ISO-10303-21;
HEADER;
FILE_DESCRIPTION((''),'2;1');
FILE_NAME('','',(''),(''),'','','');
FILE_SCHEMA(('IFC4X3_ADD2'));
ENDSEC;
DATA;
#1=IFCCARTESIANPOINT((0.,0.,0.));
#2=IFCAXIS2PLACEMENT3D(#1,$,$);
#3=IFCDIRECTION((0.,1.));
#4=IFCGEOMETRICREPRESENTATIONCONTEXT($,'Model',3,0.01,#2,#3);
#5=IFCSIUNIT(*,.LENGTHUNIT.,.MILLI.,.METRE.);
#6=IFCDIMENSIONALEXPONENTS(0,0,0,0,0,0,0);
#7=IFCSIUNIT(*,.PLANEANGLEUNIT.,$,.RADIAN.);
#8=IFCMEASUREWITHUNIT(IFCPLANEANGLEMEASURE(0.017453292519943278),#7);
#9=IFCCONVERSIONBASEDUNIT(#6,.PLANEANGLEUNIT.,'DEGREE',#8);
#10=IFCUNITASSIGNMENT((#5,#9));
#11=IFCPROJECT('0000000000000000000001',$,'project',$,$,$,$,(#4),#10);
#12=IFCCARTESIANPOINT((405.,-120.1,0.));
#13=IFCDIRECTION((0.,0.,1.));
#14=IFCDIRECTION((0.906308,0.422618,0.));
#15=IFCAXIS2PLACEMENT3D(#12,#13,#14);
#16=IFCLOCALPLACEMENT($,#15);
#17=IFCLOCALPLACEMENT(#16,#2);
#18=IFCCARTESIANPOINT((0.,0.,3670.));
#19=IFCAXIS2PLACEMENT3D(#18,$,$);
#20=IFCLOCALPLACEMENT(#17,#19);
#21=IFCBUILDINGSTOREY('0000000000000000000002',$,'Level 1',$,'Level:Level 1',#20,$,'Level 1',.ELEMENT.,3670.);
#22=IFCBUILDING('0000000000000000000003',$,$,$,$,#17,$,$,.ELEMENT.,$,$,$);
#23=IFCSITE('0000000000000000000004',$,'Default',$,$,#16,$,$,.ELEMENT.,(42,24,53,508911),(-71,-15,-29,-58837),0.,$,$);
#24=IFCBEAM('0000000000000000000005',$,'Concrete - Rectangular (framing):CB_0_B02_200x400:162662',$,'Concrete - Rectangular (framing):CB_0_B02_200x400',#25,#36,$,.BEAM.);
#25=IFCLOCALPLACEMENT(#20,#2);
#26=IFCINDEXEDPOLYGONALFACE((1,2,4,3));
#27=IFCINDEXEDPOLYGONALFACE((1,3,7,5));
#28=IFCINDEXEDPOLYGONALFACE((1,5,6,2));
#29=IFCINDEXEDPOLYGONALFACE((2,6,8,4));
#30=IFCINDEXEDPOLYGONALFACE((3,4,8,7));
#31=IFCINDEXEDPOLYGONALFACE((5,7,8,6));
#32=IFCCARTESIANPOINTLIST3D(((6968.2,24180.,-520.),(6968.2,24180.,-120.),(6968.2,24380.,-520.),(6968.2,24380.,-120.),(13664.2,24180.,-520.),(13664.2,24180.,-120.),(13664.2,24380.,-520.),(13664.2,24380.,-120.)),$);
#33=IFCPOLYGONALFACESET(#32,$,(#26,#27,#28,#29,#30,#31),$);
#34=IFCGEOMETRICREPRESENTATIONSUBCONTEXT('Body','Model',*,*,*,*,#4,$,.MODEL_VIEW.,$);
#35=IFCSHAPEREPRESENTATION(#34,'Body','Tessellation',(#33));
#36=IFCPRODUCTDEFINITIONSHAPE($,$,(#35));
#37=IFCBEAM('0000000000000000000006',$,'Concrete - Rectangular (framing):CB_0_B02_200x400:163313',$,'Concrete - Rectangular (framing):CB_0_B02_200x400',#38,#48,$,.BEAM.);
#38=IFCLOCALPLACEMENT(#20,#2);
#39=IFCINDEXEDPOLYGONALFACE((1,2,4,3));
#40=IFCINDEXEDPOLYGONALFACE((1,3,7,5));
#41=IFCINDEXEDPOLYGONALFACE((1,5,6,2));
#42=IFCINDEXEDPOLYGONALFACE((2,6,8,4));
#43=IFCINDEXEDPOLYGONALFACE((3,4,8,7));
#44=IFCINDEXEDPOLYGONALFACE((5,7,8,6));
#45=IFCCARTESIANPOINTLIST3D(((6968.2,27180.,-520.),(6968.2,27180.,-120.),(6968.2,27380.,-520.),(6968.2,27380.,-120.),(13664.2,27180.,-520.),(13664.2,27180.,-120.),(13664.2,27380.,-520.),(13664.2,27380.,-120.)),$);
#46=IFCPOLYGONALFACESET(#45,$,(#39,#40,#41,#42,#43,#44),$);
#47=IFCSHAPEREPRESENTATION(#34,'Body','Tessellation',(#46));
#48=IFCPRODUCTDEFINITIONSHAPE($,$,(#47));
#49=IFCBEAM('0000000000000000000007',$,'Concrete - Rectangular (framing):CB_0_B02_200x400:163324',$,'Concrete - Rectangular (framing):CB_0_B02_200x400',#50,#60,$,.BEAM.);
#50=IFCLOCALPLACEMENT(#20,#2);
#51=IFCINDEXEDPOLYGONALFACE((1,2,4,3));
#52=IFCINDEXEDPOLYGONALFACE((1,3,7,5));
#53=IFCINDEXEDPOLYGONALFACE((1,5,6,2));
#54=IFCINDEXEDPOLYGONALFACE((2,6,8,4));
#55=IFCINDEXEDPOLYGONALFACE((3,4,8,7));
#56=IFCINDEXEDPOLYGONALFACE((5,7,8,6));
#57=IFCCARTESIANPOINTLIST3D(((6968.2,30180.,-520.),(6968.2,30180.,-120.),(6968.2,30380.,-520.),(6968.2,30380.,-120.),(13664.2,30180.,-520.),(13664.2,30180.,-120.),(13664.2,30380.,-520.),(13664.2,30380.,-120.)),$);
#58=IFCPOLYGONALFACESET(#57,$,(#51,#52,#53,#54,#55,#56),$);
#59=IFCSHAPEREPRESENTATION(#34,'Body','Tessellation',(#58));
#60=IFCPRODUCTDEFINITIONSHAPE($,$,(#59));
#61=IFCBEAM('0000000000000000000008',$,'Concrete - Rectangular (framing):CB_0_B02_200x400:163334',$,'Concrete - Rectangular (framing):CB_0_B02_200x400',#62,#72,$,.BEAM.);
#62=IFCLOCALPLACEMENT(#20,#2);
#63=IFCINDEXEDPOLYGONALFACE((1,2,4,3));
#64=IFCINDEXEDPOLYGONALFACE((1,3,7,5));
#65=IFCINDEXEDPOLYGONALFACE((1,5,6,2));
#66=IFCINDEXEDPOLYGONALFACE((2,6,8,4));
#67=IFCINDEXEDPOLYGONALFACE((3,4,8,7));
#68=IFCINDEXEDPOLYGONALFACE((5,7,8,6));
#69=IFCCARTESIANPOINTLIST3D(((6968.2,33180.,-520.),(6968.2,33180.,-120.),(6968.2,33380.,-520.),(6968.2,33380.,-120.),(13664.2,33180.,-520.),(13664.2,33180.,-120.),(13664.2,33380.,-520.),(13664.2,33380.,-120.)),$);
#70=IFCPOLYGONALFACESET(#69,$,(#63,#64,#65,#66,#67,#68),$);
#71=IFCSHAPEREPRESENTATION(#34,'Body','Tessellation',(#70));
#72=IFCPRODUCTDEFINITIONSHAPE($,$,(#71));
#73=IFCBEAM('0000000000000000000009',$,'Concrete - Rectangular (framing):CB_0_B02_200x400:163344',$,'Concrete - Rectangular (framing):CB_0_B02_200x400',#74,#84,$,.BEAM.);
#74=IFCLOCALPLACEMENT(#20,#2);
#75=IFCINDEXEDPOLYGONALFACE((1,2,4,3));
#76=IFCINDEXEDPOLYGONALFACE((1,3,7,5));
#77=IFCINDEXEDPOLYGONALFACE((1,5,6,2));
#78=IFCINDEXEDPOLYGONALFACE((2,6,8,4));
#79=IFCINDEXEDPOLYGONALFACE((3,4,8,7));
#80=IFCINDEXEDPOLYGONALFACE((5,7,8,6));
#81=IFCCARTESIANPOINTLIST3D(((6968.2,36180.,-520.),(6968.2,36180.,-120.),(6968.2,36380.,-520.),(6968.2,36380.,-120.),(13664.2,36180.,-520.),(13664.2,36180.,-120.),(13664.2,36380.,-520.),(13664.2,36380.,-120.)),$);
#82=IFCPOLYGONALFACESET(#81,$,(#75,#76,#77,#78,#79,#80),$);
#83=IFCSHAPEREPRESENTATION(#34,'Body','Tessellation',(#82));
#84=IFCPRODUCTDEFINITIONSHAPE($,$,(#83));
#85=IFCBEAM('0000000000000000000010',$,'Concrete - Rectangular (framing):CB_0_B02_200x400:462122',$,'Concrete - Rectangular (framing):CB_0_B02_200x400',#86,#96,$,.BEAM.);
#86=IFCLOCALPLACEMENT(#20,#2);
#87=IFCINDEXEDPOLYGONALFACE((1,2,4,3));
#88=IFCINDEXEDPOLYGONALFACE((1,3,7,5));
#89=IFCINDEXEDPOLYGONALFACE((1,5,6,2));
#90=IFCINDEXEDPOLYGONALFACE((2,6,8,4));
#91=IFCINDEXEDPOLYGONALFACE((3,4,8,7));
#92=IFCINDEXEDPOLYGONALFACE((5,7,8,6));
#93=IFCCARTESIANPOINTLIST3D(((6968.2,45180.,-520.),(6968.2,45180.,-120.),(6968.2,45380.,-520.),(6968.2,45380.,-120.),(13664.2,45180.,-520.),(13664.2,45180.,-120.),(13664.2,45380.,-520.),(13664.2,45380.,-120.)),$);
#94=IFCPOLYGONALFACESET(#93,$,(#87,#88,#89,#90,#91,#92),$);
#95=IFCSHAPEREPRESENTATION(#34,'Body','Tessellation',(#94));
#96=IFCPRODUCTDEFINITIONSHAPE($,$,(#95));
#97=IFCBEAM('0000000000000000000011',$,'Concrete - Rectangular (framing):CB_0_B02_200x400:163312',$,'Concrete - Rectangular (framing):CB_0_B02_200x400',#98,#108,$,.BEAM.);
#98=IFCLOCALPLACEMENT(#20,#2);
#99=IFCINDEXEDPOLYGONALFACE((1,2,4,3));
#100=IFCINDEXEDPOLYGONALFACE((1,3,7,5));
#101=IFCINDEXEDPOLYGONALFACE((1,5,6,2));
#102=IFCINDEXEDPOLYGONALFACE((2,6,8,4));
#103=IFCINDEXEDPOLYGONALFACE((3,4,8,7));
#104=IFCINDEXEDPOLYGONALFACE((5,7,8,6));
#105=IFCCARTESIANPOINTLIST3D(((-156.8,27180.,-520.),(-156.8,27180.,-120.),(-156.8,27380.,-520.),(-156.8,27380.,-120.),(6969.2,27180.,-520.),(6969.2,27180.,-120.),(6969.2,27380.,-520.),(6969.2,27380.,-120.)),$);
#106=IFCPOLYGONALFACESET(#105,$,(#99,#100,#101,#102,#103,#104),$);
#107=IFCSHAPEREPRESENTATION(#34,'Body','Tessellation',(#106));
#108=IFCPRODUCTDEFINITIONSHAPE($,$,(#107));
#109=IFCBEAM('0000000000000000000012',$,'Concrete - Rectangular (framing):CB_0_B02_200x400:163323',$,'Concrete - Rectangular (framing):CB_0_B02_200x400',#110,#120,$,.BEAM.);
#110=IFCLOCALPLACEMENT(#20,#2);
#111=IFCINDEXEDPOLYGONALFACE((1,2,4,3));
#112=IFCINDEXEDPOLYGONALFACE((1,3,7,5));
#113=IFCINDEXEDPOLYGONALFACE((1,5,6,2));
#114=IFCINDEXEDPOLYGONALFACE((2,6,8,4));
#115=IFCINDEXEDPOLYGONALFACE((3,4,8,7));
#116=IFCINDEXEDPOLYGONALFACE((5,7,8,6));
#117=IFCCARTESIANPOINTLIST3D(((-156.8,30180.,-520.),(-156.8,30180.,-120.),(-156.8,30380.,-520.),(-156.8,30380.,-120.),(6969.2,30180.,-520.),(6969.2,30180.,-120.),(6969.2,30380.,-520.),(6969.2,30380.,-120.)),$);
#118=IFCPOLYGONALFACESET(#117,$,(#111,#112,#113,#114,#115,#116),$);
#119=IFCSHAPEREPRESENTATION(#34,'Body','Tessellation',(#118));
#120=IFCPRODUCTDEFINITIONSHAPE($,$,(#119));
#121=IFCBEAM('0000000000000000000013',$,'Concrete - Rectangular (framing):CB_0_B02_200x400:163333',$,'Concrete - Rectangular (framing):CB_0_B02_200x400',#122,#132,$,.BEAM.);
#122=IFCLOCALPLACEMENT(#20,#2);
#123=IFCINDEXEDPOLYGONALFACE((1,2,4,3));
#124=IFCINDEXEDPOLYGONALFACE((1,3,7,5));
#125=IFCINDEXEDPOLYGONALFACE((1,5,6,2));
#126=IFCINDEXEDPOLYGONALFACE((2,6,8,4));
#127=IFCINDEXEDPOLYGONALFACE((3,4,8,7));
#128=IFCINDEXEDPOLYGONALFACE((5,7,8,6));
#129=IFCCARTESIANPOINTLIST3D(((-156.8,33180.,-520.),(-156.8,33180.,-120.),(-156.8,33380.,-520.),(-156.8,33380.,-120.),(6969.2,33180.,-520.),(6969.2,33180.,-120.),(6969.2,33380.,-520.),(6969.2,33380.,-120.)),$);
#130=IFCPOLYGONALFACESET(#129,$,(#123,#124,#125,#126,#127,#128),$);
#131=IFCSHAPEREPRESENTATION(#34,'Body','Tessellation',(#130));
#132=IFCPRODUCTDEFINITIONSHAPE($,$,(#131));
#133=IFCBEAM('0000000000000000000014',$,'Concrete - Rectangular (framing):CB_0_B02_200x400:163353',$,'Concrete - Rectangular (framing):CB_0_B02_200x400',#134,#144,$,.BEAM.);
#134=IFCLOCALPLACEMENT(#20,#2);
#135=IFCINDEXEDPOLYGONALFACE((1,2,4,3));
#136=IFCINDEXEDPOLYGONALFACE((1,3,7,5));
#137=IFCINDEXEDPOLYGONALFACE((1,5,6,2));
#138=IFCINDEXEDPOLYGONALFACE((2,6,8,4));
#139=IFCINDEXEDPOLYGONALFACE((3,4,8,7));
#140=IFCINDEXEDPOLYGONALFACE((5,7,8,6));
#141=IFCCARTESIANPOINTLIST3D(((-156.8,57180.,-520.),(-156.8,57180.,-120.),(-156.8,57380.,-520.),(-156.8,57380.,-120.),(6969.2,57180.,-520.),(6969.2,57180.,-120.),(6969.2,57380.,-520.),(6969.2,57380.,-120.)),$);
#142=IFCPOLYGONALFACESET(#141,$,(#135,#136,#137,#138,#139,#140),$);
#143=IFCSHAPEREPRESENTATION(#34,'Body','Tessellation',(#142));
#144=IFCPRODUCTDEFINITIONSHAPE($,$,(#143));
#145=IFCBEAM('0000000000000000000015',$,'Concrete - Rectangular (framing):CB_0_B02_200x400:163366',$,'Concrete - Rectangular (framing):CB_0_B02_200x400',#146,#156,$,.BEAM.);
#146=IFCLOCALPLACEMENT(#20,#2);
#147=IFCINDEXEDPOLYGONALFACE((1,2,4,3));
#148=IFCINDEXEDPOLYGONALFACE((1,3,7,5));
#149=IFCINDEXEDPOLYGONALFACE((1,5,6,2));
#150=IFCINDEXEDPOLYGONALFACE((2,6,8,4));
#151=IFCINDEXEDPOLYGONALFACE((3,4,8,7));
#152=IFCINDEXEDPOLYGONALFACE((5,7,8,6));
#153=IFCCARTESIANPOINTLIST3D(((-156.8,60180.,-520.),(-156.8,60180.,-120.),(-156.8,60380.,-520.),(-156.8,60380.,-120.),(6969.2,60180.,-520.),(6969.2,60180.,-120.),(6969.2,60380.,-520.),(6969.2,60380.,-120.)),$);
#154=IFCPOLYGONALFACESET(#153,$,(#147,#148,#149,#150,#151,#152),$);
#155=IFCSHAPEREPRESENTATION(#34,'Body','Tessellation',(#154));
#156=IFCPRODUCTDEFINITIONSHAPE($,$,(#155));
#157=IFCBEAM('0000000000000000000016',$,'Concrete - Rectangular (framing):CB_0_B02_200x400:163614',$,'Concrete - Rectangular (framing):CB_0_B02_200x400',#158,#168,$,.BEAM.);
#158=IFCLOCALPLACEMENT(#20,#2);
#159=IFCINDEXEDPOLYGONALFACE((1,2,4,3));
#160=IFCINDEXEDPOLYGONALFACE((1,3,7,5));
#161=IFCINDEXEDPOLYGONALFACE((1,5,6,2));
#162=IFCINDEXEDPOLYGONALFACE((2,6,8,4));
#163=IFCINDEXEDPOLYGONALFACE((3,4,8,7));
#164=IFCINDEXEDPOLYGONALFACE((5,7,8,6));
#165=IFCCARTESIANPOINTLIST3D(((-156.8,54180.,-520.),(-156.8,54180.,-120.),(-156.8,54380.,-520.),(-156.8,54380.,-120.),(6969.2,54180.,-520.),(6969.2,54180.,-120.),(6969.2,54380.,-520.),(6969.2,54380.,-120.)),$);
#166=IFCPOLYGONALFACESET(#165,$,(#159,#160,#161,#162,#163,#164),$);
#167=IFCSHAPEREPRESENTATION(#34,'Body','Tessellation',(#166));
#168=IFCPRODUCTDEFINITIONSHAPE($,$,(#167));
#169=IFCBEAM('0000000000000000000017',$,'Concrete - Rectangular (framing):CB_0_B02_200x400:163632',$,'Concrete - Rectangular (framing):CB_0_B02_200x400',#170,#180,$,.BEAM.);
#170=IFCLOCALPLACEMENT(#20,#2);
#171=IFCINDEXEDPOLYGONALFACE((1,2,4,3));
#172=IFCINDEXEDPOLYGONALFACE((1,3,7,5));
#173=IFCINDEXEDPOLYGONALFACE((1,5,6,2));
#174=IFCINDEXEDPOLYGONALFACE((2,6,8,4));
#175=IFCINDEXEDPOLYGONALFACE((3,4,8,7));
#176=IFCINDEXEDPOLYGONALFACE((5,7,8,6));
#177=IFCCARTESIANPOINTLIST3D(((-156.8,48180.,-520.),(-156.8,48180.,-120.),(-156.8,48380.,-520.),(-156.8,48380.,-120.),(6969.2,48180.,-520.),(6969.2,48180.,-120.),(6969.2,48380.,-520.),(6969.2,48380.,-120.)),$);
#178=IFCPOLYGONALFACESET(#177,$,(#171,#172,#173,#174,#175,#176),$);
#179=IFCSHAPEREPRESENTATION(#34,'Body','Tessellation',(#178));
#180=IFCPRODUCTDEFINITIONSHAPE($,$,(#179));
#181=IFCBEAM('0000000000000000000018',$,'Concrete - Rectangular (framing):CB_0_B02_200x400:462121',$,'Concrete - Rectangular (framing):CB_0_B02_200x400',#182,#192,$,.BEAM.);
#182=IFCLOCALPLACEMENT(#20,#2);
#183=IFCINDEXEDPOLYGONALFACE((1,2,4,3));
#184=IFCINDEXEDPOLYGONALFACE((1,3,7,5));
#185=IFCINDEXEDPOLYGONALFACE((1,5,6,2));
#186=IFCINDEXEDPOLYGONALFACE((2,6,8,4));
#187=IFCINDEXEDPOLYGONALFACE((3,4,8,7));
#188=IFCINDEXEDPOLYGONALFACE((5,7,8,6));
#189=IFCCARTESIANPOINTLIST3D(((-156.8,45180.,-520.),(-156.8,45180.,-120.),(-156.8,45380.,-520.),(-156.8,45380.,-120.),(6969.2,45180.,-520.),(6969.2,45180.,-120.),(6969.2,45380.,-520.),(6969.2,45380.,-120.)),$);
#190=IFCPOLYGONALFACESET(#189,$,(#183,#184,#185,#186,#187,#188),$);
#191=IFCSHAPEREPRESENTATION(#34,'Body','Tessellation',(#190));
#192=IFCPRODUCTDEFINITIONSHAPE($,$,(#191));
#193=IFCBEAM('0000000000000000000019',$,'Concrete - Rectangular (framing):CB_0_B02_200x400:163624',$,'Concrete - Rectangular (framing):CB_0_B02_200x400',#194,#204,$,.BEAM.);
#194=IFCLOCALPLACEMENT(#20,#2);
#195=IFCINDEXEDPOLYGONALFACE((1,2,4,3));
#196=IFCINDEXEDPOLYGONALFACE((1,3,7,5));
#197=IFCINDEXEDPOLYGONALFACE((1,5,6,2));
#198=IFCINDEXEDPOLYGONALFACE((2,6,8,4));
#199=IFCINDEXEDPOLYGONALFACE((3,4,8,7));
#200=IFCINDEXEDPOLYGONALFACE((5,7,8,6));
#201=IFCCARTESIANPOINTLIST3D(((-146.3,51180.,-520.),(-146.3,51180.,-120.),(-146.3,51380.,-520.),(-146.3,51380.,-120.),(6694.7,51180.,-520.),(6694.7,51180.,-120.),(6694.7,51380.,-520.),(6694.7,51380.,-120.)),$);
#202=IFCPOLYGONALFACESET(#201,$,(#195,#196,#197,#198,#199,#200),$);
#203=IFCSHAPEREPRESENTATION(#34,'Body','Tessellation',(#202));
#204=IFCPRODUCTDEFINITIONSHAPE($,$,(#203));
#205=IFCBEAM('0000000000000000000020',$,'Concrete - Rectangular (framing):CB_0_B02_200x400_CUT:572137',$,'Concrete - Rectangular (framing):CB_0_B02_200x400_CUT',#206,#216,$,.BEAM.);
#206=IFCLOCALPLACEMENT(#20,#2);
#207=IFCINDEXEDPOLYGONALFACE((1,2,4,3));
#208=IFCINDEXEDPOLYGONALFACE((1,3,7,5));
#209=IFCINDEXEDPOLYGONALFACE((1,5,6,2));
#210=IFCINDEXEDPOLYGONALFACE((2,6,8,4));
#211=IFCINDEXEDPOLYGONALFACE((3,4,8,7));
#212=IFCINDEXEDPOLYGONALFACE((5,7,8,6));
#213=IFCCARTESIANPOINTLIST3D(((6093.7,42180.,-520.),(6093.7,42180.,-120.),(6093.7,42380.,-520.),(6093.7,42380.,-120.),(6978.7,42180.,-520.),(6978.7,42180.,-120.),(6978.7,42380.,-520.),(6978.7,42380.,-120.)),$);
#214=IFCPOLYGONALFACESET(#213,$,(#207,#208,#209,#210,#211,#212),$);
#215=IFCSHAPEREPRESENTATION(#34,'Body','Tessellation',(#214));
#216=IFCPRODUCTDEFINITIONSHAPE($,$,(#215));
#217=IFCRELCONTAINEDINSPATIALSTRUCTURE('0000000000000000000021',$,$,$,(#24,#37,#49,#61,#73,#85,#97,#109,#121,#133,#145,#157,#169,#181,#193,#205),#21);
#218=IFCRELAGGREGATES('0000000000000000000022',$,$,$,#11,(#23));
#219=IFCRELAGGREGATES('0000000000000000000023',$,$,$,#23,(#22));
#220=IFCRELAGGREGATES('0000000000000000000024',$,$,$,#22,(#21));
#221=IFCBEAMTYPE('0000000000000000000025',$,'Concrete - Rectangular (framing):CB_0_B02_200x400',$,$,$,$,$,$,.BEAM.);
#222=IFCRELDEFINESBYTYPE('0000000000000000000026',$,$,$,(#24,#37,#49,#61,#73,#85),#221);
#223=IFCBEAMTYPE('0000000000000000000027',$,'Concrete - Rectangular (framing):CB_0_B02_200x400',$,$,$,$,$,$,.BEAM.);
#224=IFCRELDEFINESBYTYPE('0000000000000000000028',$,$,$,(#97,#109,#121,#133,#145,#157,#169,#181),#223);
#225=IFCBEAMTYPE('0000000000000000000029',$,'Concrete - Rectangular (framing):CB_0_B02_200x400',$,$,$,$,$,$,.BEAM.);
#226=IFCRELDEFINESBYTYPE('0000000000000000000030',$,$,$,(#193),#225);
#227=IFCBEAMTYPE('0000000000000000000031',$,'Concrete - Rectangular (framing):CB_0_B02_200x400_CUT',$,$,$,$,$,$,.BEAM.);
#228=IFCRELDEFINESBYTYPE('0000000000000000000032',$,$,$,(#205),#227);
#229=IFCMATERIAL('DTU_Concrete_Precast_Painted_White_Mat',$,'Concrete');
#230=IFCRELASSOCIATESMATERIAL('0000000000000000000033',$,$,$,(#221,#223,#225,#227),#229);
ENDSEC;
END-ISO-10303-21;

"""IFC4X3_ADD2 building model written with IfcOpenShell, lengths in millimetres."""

from ifc_helpers import new_model, entity, si_unit, converted_unit, direction, frame, frame_2d, origin, origin_2d_with_axis, place, context, subcontext, project, spatial, rectangle, extrude, source, transform, mapped, material, material_profile, profile_set, type_object, type_shapes, element, save


model = new_model("IFC4X3_ADD2")

# Units and contexts
model_context = context("Model", 3, precision=0.01, world=origin(), true_north=direction((0.0, 1.0)))
body_context = subcontext(model_context, "Body", "Model", "MODEL_VIEW")
ifc_project = project(units=[si_unit("LENGTHUNIT", "METRE", prefix="MILLI"), converted_unit("PLANEANGLEUNIT", "DEGREE", entity("IfcPlaneAngleMeasure", 0.017453292519943278), si_unit("PLANEANGLEUNIT", "RADIAN"), dimensions=[0, 0, 0, 0, 0, 0, 0])], contexts=[model_context])

# Site, building, storey
site_placement = place(None, frame((405.0, -120.1, 0.0), z_axis=(0.0, 0.0, 1.0), x_axis=(0.906308, 0.422618, 0.0)))
site = spatial("IfcSite", under=ifc_project, at=site_placement, Name="Default", CompositionType="ELEMENT", RefLatitude=(42, 24, 53, 508911), RefLongitude=(-71, -15, -29, -58837), RefElevation=0.0)
building_placement = place(site_placement, origin())
building = spatial("IfcBuilding", under=site, at=building_placement, CompositionType="ELEMENT")
storey_placement = place(building_placement, frame((0.0, 0.0, 3670.0)))
storey = spatial("IfcBuildingStorey", under=building, at=storey_placement, Name="Level 1", ObjectType="Level:Level 1", LongName="Level 1", CompositionType="ELEMENT", Elevation=3670.0)

# Beams
ifc_material_1 = material(Name="DTU_Concrete_Precast_Painted_White_Mat", Category="Concrete")
ifc_material_profile_1 = material_profile(ifc_material_1, rectangle(XDim=7035.5, YDim=200.0, at=frame_2d((0.0, 0.0), x_axis=(1.0, 0.0))), Name="CB_0_B02_200x400")
ifc_profile_set_1 = profile_set([ifc_material_profile_1], Name="CB_0_B02_200x400")
beam_type_1 = type_object("IfcBeamType", Name="Concrete - Rectangular (framing):CB_0_B02_200x400", PredefinedType="BEAM", material=ifc_profile_set_1)
shared_shape_1 = source(origin(), body_context, "Body", "SweptSolid", [
    extrude(rectangle(XDim=6696.0, YDim=200.0, at=origin_2d_with_axis()), frame((0.0, 0.0, -200.0), z_axis=(0.0, 0.0, 1.0), x_axis=(-1.0, 0.0, 0.0)), (0.0, 0.0, 1.0), 400.0),
])
type_shapes(beam_type_1, [shared_shape_1])
for number, where, name in (
    (1, (10316.2, 24280.0, -320.0), "Concrete - Rectangular (framing):CB_0_B02_200x400:162662"),
    (2, (10316.2, 27280.0, -320.0), "Concrete - Rectangular (framing):CB_0_B02_200x400:163313"),
    (3, (10316.2, 30280.0, -320.0), "Concrete - Rectangular (framing):CB_0_B02_200x400:163324"),
    (4, (10316.2, 33280.0, -320.0), "Concrete - Rectangular (framing):CB_0_B02_200x400:163334"),
    (5, (10316.2, 36280.0, -320.0), "Concrete - Rectangular (framing):CB_0_B02_200x400:163344"),
    (6, (10316.2, 45280.0, -320.0), "Concrete - Rectangular (framing):CB_0_B02_200x400:462122"),
):
    element("IfcBeam", number, at=place(storey_placement, frame(where)), inside=storey, type_object=beam_type_1, Name=name, ObjectType="Concrete - Rectangular (framing):CB_0_B02_200x400", PredefinedType="BEAM", context=body_context, shape_type="MappedRepresentation", body=[
        mapped(shared_shape_1, transform((0.0, 0.0, 0.0), scale=1.0)),
    ])
beam_type_2 = type_object("IfcBeamType", Name="Concrete - Rectangular (framing):CB_0_B02_200x400", PredefinedType="BEAM", material=ifc_profile_set_1)
shared_shape_2 = source(origin(), body_context, "Body", "SweptSolid", [
    extrude(rectangle(XDim=7126.0, YDim=200.0, at=origin_2d_with_axis()), frame((0.0, 0.0, -200.0), z_axis=(0.0, 0.0, 1.0), x_axis=(-1.0, 0.0, 0.0)), (0.0, 0.0, 1.0), 400.0),
])
type_shapes(beam_type_2, [shared_shape_2])
for number, where, z_axis, x_axis, name in (
    (7, (3406.2, 27280.0, -320.0), (0.0, 0.0, 1.0), (-1.0, 0.0, 0.0), "Concrete - Rectangular (framing):CB_0_B02_200x400:163312"),
    (8, (3406.2, 30280.0, -320.0), (0.0, 0.0, 1.0), (-1.0, 0.0, 0.0), "Concrete - Rectangular (framing):CB_0_B02_200x400:163323"),
    (9, (3406.2, 33280.0, -320.0), (0.0, 0.0, 1.0), (-1.0, 0.0, 0.0), "Concrete - Rectangular (framing):CB_0_B02_200x400:163333"),
    (10, (3406.2, 57280.0, -320.0), (0.0, 0.0, 1.0), (-1.0, 0.0, 0.0), "Concrete - Rectangular (framing):CB_0_B02_200x400:163353"),
    (11, (3406.2, 60280.0, -320.0), (0.0, 0.0, 1.0), (-1.0, 0.0, 0.0), "Concrete - Rectangular (framing):CB_0_B02_200x400:163366"),
    (12, (3406.2, 54280.0, -320.0), (0.0, 0.0, 1.0), (-1.0, 0.0, 0.0), "Concrete - Rectangular (framing):CB_0_B02_200x400:163614"),
    (13, (3406.2, 48280.0, -320.0), (0.0, 0.0, 1.0), (-1.0, 0.0, 0.0), "Concrete - Rectangular (framing):CB_0_B02_200x400:163632"),
    (14, (3406.2, 45280.0, -320.0), (0.0, 0.0, 1.0), (-1.0, 0.0, 0.0), "Concrete - Rectangular (framing):CB_0_B02_200x400:462121"),
):
    element("IfcBeam", number, at=place(storey_placement, frame(where, z_axis=z_axis, x_axis=x_axis)), inside=storey, type_object=beam_type_2, Name=name, ObjectType="Concrete - Rectangular (framing):CB_0_B02_200x400", PredefinedType="BEAM", context=body_context, shape_type="MappedRepresentation", body=[
        mapped(shared_shape_2, transform((0.0, 0.0, 0.0), scale=1.0)),
    ])
beam_type_3 = type_object("IfcBeamType", Name="Concrete - Rectangular (framing):CB_0_B02_200x400", PredefinedType="BEAM", material=ifc_profile_set_1)
shared_shape_3 = source(origin(), body_context, "Body", "SweptSolid", [
    extrude(rectangle(XDim=6841.0, YDim=200.0, at=frame_2d((0.0, 0.0), x_axis=(1.0, 0.0))), frame((0.0, 0.0, -200.0), z_axis=(0.0, 0.0, 1.0), x_axis=(-1.0, 0.0, 0.0)), (0.0, 0.0, 1.0), 400.0),
])
type_shapes(beam_type_3, [shared_shape_3])
beam_1_placement = place(storey_placement, frame((3274.2, 51280.0, -320.0), z_axis=(0.0, 0.0, 1.0), x_axis=(-1.0, 0.0, 0.0)))
element("IfcBeam", 15, at=beam_1_placement, inside=storey, type_object=beam_type_3, Name="Concrete - Rectangular (framing):CB_0_B02_200x400:163624", ObjectType="Concrete - Rectangular (framing):CB_0_B02_200x400", PredefinedType="BEAM", context=body_context, shape_type="MappedRepresentation", body=[
    mapped(shared_shape_3, transform((0.0, 0.0, 0.0), scale=1.0)),
])
ifc_material_profile_2 = material_profile(ifc_material_1, rectangle(XDim=885.0, YDim=200.0, at=origin_2d_with_axis()), Name="CB_0_B02_200x400_CUT")
ifc_profile_set_2 = profile_set([ifc_material_profile_2], Name="CB_0_B02_200x400_CUT")
beam_type_4 = type_object("IfcBeamType", Name="Concrete - Rectangular (framing):CB_0_B02_200x400_CUT", PredefinedType="BEAM", material=ifc_profile_set_2)
shared_shape_4 = source(origin(), body_context, "Body", "SweptSolid", [
    extrude(rectangle(XDim=885.0, YDim=200.0, at=origin_2d_with_axis()), frame((0.0, 0.0, -200.0), z_axis=(0.0, 0.0, 1.0), x_axis=(-1.0, 0.0, 0.0)), (0.0, 0.0, 1.0), 400.0),
])
type_shapes(beam_type_4, [shared_shape_4])
for number, where, z_axis, x_axis, name in (
    (16, (6536.2, 42280.0, -320.0), (0.0, 0.0, 1.0), (-1.0, 0.0, 0.0), "Concrete - Rectangular (framing):CB_0_B02_200x400_CUT:572137"),
):
    element("IfcBeam", number, at=place(storey_placement, frame(where, z_axis=z_axis, x_axis=x_axis)), inside=storey, type_object=beam_type_4, Name=name, ObjectType="Concrete - Rectangular (framing):CB_0_B02_200x400_CUT", PredefinedType="BEAM", context=body_context, shape_type="MappedRepresentation", body=[
        mapped(shared_shape_4, transform((0.0, 0.0, 0.0), scale=1.0)),
    ])

save(model, "model.ifc")
